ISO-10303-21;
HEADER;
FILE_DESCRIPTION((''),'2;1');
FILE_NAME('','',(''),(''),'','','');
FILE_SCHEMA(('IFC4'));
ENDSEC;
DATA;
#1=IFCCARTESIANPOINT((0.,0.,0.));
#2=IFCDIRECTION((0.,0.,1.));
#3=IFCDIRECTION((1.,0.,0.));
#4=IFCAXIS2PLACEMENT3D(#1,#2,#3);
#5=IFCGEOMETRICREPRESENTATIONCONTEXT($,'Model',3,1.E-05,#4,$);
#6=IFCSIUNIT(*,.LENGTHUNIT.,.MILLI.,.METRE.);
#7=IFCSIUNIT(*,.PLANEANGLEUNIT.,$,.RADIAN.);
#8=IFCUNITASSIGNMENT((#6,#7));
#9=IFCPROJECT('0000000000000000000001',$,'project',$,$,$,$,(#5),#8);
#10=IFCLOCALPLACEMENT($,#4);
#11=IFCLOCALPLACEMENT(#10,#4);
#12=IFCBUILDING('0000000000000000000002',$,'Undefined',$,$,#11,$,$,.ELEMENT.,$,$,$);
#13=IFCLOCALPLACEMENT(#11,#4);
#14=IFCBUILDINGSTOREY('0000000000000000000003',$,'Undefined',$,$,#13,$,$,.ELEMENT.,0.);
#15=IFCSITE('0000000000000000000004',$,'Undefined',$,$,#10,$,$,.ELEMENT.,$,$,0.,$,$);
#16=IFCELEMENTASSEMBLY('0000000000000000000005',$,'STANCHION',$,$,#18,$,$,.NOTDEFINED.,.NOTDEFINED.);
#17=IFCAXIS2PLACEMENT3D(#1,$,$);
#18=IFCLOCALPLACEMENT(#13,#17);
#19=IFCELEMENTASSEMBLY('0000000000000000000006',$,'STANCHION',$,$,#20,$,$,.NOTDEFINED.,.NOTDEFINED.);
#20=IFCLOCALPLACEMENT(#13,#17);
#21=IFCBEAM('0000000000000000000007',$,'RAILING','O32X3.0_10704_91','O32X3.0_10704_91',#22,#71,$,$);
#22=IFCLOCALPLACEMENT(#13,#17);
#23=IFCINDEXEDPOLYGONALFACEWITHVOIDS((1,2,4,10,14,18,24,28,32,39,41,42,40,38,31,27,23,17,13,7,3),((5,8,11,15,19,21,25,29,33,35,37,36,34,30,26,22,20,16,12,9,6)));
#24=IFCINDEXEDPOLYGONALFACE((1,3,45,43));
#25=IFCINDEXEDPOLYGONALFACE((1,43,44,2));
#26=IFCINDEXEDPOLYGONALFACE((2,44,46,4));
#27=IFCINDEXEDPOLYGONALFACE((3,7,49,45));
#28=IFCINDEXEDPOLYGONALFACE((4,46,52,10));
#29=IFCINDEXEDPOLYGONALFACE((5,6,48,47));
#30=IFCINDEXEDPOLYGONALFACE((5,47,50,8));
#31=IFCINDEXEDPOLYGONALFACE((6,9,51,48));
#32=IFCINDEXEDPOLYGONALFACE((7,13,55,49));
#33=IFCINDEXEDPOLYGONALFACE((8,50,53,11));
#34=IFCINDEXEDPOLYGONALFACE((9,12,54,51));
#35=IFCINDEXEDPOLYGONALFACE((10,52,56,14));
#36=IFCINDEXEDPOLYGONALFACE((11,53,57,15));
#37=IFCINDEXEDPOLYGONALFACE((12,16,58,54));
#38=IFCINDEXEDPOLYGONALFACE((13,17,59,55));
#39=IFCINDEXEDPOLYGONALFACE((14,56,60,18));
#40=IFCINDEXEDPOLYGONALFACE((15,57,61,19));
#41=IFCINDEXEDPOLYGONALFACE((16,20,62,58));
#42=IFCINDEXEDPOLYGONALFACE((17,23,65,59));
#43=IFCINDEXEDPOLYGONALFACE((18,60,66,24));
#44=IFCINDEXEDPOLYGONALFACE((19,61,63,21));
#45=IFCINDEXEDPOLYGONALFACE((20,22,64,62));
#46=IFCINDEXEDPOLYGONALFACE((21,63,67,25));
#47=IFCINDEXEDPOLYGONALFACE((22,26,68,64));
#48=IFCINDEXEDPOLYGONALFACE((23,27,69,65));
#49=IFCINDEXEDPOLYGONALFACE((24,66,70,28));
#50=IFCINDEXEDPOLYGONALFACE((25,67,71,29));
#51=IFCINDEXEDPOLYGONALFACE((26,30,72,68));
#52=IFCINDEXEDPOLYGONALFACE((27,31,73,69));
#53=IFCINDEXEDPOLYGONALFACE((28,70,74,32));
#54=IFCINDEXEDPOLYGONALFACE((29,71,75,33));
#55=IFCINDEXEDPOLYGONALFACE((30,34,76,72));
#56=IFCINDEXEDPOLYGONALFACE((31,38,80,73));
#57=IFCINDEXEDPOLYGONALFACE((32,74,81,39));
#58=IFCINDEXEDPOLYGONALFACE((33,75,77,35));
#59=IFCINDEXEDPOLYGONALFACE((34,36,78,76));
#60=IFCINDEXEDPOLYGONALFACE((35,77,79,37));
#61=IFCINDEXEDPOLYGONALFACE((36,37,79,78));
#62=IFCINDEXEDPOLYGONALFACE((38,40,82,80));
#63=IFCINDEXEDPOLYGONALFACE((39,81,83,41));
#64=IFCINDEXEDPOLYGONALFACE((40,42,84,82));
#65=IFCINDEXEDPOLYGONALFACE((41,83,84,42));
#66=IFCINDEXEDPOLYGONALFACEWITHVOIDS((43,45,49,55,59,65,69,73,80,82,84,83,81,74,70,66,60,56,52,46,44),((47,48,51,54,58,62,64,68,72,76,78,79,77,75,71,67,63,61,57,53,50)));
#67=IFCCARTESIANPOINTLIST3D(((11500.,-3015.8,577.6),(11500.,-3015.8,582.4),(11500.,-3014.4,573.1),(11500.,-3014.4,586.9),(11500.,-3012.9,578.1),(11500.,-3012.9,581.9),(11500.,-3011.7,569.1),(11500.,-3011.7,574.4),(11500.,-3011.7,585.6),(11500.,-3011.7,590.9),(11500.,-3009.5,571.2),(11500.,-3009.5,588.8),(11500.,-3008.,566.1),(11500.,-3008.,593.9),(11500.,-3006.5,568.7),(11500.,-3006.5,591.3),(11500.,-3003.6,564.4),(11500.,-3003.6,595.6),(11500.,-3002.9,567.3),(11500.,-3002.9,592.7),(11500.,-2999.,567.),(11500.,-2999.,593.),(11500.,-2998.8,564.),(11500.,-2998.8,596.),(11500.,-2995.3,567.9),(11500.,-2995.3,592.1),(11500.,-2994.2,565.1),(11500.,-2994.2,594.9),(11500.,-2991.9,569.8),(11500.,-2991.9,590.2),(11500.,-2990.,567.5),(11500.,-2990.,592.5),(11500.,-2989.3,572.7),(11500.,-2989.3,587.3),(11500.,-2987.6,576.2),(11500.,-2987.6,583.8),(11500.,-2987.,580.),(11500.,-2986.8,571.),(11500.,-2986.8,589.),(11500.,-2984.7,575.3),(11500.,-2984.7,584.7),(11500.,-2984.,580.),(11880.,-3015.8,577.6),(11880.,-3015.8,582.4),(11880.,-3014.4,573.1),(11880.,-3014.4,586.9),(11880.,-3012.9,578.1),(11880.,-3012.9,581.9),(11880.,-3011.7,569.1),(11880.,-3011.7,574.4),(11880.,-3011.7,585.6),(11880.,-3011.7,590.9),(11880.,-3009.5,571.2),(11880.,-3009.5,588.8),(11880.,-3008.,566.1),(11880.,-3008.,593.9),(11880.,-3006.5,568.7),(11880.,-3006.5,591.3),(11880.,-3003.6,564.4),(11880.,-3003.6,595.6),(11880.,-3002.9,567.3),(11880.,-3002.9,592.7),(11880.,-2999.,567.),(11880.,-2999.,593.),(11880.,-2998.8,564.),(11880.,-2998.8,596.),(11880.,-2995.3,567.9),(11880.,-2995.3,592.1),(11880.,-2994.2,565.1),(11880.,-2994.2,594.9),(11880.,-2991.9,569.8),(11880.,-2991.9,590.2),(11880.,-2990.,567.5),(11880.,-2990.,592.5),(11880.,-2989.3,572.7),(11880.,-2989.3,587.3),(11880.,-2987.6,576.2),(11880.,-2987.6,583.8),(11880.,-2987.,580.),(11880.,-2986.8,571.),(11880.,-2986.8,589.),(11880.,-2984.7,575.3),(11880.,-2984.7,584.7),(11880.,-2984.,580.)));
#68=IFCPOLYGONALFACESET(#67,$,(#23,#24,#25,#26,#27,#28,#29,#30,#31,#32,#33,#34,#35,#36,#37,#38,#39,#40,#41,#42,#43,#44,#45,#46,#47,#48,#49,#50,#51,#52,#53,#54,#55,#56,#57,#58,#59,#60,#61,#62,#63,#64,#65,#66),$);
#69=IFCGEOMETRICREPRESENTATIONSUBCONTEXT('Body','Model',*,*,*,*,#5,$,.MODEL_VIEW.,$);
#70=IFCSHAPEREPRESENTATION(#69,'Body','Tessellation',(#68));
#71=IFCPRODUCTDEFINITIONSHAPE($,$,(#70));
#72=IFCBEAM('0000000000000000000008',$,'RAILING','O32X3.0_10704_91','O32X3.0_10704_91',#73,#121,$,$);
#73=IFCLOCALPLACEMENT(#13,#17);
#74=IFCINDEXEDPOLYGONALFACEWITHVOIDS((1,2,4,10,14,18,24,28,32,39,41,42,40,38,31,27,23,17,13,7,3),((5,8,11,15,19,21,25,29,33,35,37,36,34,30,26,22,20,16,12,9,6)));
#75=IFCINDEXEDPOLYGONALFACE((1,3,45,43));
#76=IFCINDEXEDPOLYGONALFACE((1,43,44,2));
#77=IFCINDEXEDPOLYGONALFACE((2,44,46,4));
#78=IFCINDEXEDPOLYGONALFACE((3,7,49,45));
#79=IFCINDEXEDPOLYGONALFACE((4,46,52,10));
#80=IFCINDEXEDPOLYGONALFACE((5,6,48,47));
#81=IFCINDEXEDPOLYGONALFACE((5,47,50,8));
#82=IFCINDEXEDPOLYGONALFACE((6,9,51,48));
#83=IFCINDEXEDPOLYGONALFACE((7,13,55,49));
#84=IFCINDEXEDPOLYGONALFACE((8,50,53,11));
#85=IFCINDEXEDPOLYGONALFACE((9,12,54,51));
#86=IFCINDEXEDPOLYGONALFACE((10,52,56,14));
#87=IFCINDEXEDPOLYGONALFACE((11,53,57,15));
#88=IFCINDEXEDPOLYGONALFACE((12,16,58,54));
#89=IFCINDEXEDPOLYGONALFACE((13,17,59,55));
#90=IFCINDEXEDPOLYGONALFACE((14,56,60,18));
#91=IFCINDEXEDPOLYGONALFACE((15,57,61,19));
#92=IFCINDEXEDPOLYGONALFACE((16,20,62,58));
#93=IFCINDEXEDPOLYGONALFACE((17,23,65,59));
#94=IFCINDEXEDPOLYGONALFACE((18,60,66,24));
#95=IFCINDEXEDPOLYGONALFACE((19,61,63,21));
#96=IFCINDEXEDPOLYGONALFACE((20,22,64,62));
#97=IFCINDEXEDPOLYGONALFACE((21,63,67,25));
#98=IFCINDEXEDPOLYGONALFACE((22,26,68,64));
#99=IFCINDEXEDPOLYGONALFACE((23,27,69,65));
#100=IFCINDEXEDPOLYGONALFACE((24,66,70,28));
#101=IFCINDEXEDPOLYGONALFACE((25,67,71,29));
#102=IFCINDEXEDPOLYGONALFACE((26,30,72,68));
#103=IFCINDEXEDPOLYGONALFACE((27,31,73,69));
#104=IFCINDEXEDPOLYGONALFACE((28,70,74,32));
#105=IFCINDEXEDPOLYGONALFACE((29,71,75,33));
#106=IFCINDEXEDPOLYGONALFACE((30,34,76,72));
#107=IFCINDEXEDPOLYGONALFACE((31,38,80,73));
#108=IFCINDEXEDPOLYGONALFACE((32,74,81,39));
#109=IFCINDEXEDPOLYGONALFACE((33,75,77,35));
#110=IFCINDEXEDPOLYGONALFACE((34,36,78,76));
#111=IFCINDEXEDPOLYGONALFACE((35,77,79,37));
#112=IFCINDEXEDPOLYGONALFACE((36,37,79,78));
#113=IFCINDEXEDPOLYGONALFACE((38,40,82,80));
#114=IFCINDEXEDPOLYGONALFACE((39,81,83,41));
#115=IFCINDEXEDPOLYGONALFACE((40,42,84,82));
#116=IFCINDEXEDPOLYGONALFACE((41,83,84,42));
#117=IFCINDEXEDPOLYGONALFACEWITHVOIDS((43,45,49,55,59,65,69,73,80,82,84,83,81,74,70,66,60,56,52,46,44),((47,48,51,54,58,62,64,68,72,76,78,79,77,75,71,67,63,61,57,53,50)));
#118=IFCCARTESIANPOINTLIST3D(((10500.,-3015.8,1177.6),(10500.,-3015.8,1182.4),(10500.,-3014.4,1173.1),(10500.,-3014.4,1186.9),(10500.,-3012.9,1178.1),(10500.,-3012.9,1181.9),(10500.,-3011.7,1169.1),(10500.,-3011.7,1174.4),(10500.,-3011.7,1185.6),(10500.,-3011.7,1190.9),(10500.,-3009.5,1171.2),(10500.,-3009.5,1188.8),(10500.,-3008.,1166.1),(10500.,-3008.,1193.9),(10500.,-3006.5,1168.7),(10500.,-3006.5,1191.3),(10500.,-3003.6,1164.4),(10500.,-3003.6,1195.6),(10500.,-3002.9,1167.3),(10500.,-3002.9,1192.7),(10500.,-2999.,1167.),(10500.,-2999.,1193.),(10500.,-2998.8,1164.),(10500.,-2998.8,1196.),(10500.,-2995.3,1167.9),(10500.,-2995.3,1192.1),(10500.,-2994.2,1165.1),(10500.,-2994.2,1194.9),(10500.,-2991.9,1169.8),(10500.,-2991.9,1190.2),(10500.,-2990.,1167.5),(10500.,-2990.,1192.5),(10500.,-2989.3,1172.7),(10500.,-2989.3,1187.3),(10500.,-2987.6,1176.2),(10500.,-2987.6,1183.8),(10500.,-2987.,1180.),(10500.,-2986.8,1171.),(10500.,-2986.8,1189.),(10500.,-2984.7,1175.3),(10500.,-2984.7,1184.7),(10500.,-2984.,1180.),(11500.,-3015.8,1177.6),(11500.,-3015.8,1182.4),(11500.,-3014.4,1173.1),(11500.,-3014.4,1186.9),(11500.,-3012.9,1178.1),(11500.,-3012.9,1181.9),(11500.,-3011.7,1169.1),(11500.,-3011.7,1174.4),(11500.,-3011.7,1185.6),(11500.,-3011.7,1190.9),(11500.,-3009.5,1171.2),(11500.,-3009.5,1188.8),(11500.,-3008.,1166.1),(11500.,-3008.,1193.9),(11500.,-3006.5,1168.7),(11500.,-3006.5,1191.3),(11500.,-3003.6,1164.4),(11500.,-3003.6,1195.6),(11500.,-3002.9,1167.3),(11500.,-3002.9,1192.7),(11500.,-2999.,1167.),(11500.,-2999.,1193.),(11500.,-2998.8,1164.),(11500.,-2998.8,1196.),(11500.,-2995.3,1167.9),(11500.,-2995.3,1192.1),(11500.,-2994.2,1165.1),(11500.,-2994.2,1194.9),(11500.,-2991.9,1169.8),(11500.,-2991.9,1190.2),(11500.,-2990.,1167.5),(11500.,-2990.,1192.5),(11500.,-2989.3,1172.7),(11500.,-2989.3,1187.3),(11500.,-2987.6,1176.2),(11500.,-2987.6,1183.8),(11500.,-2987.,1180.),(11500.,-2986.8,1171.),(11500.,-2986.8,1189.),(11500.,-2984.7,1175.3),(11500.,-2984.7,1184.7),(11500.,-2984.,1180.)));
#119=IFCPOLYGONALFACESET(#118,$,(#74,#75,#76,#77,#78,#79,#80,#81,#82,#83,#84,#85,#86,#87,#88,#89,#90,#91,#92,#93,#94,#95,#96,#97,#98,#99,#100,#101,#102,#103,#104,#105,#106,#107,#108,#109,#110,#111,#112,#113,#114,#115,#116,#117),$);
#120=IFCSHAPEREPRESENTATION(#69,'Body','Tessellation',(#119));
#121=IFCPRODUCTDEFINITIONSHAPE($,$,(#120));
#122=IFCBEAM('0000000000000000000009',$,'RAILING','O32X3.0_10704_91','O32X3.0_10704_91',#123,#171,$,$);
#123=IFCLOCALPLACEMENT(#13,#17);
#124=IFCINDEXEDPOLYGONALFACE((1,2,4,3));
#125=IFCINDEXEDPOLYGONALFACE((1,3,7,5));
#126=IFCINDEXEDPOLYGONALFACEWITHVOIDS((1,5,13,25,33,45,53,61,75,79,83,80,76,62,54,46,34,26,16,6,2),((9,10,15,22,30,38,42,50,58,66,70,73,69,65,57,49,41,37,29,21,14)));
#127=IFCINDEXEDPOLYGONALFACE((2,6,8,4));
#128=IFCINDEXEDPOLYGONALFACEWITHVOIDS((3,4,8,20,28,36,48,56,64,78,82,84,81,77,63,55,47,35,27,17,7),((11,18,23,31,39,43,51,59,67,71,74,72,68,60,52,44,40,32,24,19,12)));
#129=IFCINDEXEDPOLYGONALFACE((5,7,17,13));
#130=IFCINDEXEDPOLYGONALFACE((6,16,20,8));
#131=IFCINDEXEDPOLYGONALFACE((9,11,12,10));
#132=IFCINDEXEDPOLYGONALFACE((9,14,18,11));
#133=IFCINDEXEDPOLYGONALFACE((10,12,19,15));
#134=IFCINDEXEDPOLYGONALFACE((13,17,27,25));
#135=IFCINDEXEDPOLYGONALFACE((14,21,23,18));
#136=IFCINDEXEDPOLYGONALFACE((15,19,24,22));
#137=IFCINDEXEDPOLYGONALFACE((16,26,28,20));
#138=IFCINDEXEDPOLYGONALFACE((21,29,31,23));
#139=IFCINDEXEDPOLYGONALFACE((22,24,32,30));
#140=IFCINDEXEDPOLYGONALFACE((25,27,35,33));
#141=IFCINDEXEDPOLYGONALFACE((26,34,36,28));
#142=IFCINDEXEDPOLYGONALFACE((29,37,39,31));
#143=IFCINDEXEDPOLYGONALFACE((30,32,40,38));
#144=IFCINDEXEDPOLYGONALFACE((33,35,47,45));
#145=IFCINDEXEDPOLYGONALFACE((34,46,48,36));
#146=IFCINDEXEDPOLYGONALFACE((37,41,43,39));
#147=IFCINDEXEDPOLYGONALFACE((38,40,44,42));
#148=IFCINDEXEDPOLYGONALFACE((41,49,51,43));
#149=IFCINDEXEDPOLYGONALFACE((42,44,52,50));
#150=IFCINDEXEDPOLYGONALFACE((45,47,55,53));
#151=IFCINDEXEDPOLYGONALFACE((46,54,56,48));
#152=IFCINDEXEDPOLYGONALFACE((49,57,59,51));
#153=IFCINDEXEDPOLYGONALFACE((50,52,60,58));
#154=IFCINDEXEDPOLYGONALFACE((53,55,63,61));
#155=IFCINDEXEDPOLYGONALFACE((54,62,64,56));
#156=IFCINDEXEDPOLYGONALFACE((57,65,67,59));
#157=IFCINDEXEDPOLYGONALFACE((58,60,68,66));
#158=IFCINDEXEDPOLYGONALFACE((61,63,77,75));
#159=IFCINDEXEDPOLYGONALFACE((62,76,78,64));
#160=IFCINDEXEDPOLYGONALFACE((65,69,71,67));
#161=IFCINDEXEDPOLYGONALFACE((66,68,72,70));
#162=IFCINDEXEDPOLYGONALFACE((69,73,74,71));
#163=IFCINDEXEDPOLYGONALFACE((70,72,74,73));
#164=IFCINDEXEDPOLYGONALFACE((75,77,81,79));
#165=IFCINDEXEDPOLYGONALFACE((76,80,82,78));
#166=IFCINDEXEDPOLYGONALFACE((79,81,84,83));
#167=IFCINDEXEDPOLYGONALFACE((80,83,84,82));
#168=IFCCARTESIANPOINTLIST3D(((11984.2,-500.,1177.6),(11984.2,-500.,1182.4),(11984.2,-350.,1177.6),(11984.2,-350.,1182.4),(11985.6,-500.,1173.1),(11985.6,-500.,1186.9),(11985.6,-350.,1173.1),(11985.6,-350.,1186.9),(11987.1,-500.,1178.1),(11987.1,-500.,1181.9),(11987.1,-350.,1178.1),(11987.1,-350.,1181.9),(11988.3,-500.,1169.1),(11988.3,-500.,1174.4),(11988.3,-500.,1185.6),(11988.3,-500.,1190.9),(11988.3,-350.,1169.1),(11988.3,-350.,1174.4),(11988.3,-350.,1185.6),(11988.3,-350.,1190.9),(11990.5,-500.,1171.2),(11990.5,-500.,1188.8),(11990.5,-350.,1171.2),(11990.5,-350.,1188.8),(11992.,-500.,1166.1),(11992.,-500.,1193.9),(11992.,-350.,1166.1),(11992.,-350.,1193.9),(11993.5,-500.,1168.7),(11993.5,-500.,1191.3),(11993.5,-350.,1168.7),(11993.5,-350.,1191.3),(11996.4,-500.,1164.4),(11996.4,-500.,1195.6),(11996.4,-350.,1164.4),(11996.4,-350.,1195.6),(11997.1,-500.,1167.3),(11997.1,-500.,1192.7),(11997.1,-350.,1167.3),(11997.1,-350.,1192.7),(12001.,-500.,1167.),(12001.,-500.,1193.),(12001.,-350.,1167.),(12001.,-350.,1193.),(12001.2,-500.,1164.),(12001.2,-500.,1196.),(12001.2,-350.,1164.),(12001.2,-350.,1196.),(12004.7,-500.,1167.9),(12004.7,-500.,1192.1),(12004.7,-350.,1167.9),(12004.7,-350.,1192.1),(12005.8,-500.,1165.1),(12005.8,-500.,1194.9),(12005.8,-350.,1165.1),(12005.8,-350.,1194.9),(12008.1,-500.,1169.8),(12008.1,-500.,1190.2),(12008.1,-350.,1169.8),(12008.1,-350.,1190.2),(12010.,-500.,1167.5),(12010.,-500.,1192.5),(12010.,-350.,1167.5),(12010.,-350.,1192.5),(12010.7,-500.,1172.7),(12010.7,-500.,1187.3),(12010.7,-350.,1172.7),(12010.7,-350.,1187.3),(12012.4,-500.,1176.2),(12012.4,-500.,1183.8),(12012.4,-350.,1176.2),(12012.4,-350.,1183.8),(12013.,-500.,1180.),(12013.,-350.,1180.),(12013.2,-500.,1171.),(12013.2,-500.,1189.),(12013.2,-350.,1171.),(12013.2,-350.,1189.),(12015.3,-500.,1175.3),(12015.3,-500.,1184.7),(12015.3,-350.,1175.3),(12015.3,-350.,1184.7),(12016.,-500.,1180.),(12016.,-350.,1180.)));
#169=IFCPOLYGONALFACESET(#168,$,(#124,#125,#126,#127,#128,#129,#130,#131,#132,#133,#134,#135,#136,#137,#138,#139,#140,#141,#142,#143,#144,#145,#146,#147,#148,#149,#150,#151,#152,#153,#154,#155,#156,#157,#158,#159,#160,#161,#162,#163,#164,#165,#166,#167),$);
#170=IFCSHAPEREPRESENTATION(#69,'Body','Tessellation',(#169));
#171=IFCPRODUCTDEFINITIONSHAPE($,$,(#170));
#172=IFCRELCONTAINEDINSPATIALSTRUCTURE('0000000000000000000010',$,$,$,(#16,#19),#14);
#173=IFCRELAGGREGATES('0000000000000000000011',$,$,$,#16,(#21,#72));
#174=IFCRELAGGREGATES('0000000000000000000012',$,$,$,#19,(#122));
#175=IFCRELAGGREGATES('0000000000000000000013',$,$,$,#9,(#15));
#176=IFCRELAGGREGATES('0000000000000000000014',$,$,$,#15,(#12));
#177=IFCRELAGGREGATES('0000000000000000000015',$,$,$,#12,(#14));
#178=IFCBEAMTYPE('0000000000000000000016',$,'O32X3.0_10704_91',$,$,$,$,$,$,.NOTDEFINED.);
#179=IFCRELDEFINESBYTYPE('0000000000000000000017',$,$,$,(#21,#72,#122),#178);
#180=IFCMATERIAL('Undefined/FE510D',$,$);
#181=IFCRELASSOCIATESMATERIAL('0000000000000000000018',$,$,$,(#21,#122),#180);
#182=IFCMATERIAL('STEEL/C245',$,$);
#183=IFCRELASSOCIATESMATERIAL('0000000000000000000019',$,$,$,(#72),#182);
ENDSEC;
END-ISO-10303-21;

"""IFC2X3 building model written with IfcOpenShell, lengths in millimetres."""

from ifc_helpers import new_model, si_unit, frame, origin_with_axes, origin_2d_with_axis, place, context, subcontext, project, spatial, hollow_circle, extrude, material, type_object, element, aggregate, save


model = new_model("IFC2X3")

# Units and contexts
model_context = context("Model", 3, precision=1e-05, world=origin_with_axes())
body_context = subcontext(model_context, "Body", "Model", "MODEL_VIEW")
ifc_project = project(units=[si_unit("LENGTHUNIT", "METRE", prefix="MILLI"), si_unit("PLANEANGLEUNIT", "RADIAN")], contexts=[model_context])

# Site, building, storey
site_placement = place(None, origin_with_axes())
site = spatial("IfcSite", under=ifc_project, at=site_placement, Name="Undefined", CompositionType="ELEMENT", RefElevation=0.0)
building_placement = place(site_placement, origin_with_axes())
building = spatial("IfcBuilding", under=site, at=building_placement, Name="Undefined", CompositionType="ELEMENT")
storey_placement = place(building_placement, origin_with_axes())
storey = spatial("IfcBuildingStorey", under=building, at=storey_placement, Name="Undefined", CompositionType="ELEMENT", Elevation=0.0)

# Element assemblies
assembly_1_placement = place(storey_placement, origin_with_axes())
assembly_1 = element("IfcElementAssembly", 1, at=assembly_1_placement, inside=storey, Name="STANCHION", AssemblyPlace="NOTDEFINED", PredefinedType="NOTDEFINED")
ifc_material_1 = material(Name="STEEL/C245")
assembly_2_placement = place(storey_placement, origin_with_axes())
assembly_2 = element("IfcElementAssembly", 2, at=assembly_2_placement, inside=storey, Name="STANCHION", AssemblyPlace="NOTDEFINED", PredefinedType="NOTDEFINED")
ifc_material_2 = material(Name="Undefined/FE510D")

# Beams
beam_type_1 = type_object("IfcBeamType", Name="O32X3.0_10704_91", PredefinedType="NOTDEFINED")
beam_1_placement = place(assembly_1_placement, frame((11500.0, -3000.0, 580.0), z_axis=(0.0, 0.0, -1.0), x_axis=(1.0, 0.0, 0.0)))
beam_1 = element("IfcBeam", 3, at=beam_1_placement, type_object=beam_type_1, material=ifc_material_2, Name="RAILING", Description="O32X3.0_10704_91", ObjectType="O32X3.0_10704_91", context=body_context, shape_type="SweptSolid", body=[
    extrude(hollow_circle(Radius=16.0, WallThickness=3.0, at=origin_2d_with_axis()), frame((380.0, 0.0, 0.0), z_axis=(-1.0, 0.0, 0.0), x_axis=(0.0, -1.0, 0.0)), (0.0, 0.0, 1.0), 380.0),
])
beam_2_placement = place(assembly_1_placement, frame((10500.0, -3000.0, 1180.0), z_axis=(0.0, 0.0, -1.0), x_axis=(1.0, 0.0, 0.0)))
beam_2 = element("IfcBeam", 4, at=beam_2_placement, type_object=beam_type_1, material=ifc_material_1, Name="RAILING", Description="O32X3.0_10704_91", ObjectType="O32X3.0_10704_91", context=body_context, shape_type="SweptSolid", body=[
    extrude(hollow_circle(Radius=16.0, WallThickness=3.0, at=origin_2d_with_axis()), frame((1000.0, 0.0, 0.0), z_axis=(-1.0, 0.0, 0.0), x_axis=(0.0, -1.0, 0.0)), (0.0, 0.0, 1.0), 1000.0),
])
aggregate(assembly_1, [beam_1, beam_2])
beam_3_placement = place(assembly_2_placement, frame((12000.0, -500.0, 1180.0), z_axis=(0.0, 0.0, 1.0), x_axis=(0.0, 1.0, 0.0)))
beam_3 = element("IfcBeam", 5, at=beam_3_placement, type_object=beam_type_1, material=ifc_material_2, Name="RAILING", Description="O32X3.0_10704_91", ObjectType="O32X3.0_10704_91", context=body_context, shape_type="SweptSolid", body=[
    extrude(hollow_circle(Radius=16.0, WallThickness=3.0, at=origin_2d_with_axis()), frame((150.0, 0.0, 0.0), z_axis=(-1.0, 0.0, 0.0), x_axis=(0.0, -1.0, 0.0)), (0.0, 0.0, 1.0), 150.0),
])
aggregate(assembly_2, [beam_3])

save(model, "model.ifc")
